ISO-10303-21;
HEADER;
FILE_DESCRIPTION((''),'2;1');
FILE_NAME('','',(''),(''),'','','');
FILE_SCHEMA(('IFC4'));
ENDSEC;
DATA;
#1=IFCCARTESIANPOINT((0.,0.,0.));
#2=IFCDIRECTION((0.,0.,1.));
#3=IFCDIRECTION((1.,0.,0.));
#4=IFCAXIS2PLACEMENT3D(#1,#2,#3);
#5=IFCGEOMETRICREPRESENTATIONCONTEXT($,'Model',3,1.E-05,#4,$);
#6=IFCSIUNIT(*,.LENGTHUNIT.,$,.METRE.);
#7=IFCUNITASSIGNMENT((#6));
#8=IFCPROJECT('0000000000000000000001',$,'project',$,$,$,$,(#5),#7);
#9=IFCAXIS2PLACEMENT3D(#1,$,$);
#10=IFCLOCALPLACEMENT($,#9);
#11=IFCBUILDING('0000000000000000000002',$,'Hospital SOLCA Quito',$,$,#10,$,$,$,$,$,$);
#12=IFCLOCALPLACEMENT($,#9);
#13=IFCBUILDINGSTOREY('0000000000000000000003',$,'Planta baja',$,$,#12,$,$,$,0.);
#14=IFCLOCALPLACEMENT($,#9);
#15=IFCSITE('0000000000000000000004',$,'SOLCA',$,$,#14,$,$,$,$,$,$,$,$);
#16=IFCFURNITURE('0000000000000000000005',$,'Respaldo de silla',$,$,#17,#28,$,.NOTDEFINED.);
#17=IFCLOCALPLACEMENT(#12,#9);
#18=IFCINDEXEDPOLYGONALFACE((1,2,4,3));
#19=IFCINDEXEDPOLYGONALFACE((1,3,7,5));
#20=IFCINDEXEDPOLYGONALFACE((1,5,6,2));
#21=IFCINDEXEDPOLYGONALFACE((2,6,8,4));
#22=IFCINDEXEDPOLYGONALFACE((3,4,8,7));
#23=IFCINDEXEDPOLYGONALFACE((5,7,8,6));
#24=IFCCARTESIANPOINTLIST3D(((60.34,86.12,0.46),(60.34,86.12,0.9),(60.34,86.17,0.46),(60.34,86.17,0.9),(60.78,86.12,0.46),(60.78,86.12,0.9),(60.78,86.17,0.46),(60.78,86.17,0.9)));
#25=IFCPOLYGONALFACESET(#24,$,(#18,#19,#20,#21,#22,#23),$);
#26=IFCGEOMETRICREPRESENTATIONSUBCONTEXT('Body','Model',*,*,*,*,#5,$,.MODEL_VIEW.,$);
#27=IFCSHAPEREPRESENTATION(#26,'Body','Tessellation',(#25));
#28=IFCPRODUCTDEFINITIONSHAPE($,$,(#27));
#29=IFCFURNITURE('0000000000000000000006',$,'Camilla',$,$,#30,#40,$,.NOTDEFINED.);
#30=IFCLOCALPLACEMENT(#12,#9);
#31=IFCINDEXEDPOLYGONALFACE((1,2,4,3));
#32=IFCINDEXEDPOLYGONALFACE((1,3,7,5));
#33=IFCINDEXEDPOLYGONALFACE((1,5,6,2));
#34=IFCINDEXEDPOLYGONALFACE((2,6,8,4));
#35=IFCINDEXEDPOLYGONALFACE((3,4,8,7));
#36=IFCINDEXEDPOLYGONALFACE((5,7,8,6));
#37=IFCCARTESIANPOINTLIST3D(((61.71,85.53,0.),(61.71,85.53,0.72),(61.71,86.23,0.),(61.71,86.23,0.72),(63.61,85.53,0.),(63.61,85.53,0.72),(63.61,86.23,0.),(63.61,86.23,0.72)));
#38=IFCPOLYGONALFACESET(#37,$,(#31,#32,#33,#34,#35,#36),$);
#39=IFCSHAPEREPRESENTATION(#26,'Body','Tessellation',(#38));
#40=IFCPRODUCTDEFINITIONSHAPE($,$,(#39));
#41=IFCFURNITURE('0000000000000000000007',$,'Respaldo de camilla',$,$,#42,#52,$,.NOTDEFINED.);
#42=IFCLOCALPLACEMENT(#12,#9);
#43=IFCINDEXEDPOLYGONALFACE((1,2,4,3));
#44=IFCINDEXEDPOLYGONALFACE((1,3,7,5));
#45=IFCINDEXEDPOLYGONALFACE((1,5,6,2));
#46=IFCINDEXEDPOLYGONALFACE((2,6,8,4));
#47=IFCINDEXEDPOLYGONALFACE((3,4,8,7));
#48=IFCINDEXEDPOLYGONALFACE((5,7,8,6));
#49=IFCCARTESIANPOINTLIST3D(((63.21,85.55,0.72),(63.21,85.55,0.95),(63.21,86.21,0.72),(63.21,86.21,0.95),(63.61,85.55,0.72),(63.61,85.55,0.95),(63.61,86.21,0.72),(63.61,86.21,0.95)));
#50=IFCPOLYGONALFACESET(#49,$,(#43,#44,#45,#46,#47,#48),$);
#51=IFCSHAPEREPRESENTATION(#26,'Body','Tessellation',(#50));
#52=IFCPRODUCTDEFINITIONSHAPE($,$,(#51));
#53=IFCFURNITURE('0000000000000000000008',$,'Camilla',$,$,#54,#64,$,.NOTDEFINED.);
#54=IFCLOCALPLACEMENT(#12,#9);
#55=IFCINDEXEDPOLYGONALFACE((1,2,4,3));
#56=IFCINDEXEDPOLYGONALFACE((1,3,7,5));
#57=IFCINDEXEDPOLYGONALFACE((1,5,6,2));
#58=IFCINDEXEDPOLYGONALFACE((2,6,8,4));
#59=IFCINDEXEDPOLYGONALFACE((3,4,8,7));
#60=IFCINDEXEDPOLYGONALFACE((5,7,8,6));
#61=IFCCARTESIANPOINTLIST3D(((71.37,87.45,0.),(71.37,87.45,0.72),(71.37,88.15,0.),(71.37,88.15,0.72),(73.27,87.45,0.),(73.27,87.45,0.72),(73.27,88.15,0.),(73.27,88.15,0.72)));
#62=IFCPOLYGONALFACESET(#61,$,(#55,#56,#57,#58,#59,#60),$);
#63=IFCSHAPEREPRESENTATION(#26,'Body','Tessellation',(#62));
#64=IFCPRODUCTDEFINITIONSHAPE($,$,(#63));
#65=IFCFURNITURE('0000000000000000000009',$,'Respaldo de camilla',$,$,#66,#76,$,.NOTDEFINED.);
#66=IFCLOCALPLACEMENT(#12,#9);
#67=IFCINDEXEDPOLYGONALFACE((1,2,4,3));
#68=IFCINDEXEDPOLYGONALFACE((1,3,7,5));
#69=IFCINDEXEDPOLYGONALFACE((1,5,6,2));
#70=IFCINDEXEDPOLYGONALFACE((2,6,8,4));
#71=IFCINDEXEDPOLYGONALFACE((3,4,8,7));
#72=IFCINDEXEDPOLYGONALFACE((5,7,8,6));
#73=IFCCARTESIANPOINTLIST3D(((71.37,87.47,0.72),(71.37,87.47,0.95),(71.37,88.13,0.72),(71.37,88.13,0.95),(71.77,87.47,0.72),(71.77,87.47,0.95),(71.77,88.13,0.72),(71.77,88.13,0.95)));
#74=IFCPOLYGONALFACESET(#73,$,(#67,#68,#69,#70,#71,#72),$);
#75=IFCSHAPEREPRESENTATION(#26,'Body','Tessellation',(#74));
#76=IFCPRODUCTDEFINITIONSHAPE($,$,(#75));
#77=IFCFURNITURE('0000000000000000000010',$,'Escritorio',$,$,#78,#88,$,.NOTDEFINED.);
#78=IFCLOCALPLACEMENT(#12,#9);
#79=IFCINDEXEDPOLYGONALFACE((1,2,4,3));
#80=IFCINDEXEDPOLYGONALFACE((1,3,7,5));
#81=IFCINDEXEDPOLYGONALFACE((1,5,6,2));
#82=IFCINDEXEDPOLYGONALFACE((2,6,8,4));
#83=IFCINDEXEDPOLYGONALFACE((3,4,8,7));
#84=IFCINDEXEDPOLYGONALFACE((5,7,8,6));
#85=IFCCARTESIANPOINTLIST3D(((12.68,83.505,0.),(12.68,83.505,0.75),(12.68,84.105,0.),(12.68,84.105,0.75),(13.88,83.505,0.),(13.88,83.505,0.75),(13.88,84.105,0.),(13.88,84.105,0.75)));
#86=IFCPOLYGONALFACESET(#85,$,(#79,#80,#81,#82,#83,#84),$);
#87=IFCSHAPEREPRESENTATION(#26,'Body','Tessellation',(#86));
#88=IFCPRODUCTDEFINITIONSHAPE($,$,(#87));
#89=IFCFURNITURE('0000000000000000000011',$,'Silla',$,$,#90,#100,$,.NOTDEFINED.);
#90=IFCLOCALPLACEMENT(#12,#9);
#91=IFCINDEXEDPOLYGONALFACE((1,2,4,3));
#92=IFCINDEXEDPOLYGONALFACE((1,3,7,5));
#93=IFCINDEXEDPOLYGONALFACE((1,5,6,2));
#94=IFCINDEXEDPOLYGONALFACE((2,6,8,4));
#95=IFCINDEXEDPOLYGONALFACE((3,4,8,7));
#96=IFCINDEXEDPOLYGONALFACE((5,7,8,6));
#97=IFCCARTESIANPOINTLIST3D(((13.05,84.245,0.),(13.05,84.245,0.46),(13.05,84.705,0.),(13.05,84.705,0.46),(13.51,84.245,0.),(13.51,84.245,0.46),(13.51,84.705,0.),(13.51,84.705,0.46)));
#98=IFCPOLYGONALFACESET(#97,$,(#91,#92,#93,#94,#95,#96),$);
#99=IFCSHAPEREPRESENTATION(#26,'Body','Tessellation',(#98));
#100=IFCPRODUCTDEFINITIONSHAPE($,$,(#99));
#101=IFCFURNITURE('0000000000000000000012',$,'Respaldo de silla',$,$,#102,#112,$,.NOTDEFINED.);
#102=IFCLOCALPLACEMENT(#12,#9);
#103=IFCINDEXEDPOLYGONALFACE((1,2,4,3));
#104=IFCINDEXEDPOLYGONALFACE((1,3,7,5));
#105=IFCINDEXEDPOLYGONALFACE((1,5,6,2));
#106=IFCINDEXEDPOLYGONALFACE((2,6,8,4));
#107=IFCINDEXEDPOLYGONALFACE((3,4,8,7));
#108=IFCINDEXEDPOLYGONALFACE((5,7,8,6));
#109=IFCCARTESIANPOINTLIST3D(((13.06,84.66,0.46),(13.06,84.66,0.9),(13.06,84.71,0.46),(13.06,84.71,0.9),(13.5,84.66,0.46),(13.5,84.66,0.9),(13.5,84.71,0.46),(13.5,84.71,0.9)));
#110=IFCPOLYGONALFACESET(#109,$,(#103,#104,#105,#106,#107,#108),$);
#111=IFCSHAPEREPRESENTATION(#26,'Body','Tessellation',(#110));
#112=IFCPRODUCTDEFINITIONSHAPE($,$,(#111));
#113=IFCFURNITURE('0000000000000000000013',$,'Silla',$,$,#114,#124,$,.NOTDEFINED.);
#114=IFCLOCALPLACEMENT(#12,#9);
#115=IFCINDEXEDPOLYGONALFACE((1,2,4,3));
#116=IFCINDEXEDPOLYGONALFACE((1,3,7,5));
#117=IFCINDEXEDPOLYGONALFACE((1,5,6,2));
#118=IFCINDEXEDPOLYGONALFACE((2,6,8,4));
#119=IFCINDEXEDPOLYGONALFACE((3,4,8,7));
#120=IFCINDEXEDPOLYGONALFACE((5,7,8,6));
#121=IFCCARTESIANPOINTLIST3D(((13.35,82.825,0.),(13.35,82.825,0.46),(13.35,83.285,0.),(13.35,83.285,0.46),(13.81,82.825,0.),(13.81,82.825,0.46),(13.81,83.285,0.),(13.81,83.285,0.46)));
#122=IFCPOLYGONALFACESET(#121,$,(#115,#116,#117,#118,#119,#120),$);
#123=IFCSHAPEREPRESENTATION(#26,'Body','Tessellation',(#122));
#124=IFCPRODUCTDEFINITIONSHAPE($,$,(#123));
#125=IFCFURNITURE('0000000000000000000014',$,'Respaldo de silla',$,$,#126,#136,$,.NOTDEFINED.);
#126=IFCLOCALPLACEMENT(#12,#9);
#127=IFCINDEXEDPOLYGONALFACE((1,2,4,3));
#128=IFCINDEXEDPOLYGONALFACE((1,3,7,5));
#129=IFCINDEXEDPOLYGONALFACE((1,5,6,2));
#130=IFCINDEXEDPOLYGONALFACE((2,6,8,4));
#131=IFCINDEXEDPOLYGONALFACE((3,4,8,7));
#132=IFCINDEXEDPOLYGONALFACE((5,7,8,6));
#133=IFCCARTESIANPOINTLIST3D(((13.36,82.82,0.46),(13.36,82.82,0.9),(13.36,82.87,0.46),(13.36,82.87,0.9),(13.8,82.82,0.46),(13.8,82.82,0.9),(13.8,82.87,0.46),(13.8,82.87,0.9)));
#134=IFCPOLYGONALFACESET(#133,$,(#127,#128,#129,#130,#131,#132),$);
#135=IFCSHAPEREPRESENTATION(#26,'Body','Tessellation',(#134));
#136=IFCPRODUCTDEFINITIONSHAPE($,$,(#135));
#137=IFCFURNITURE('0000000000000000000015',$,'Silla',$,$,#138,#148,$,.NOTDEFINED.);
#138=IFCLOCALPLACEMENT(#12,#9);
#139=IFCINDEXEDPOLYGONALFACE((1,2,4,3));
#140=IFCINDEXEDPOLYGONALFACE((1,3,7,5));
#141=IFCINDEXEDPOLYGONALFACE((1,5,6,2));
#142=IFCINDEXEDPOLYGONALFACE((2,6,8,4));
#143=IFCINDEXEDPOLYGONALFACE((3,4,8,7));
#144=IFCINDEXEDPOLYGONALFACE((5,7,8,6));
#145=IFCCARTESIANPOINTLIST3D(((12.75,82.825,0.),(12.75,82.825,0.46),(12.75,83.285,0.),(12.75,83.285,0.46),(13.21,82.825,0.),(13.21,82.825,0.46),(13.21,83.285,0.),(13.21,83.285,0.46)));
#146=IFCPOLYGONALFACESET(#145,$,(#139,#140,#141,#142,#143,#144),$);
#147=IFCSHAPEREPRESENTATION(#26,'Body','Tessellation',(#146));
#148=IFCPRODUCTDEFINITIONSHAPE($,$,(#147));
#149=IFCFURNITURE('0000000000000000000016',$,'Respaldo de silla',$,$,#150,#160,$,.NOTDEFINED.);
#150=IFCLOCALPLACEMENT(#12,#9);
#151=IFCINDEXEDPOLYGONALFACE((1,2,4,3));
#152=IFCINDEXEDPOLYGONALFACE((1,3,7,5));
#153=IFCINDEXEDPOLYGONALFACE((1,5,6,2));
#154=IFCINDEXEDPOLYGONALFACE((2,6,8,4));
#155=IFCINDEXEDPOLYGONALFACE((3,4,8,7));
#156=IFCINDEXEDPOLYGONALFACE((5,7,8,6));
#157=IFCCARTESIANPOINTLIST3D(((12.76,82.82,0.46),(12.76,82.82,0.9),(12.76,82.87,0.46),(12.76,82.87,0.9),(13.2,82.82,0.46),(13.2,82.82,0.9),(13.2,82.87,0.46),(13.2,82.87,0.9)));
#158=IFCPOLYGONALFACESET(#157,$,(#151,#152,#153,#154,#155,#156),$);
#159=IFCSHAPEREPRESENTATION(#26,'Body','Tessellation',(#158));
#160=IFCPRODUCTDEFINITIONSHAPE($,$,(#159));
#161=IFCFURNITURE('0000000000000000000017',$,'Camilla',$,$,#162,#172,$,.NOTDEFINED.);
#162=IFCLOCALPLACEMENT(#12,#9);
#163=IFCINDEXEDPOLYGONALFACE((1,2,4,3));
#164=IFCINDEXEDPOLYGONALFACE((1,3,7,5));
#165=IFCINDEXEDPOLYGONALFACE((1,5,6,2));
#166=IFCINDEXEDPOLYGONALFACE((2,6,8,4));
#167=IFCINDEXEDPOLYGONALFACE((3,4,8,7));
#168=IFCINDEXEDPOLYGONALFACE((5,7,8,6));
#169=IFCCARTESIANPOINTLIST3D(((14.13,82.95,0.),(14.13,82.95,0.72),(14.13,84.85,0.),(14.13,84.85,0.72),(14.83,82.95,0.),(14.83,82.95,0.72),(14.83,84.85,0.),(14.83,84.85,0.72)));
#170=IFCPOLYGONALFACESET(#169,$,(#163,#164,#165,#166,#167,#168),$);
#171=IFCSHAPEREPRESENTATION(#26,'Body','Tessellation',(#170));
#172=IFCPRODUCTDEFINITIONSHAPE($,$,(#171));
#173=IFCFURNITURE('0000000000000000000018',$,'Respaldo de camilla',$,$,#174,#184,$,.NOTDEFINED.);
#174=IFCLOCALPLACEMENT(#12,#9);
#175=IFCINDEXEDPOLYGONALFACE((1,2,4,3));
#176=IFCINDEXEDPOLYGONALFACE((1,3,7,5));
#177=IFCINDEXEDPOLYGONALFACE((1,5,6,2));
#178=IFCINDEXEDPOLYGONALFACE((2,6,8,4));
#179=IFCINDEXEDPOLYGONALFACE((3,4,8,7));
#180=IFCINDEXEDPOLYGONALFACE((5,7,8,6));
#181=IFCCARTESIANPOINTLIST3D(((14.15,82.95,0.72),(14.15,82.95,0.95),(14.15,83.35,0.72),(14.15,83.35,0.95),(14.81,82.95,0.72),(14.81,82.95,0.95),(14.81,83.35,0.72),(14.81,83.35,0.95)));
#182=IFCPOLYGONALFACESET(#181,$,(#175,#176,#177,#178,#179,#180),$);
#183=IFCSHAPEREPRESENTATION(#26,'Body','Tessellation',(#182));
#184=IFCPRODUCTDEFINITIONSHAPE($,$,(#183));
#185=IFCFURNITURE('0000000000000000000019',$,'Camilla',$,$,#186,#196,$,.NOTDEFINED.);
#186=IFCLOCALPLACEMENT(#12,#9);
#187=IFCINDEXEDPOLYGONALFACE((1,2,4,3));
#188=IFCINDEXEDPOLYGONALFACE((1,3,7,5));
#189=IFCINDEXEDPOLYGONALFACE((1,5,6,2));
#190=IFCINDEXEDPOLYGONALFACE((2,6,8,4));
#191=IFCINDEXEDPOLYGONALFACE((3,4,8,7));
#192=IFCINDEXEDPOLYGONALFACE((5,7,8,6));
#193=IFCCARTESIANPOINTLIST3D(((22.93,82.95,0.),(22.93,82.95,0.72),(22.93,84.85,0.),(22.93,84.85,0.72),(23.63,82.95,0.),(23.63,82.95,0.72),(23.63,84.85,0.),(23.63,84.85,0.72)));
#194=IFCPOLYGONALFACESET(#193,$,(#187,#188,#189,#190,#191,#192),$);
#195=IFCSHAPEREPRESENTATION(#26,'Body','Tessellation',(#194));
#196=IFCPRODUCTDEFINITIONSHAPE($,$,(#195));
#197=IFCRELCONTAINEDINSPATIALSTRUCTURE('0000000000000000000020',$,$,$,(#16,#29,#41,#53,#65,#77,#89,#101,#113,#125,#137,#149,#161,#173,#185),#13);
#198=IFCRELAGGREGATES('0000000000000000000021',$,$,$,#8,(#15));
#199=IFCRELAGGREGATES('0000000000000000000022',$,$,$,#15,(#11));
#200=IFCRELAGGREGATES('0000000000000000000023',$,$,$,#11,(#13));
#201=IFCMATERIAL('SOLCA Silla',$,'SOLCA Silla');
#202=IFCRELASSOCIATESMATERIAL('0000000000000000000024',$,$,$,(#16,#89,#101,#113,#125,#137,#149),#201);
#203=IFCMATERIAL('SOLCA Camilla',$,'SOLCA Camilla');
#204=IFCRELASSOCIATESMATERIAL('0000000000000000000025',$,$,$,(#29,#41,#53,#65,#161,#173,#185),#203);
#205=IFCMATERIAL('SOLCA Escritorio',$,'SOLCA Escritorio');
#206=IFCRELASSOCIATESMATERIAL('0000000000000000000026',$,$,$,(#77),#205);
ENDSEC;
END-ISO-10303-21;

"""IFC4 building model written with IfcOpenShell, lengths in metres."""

from ifc_helpers import new_model, si_unit, frame, origin, origin_with_axes, place, context, subcontext, project, spatial, polyline, outline, extrude, material, element, save


model = new_model("IFC4")

# Units and contexts
model_context = context("Model", 3, precision=1e-05, world=origin_with_axes())
body_context = subcontext(model_context, "Body", "Model", "MODEL_VIEW")
ifc_project = project(units=[si_unit("LENGTHUNIT", "METRE")], contexts=[model_context])

# Site, building, storey
site_placement = place(None, origin())
site = spatial("IfcSite", under=ifc_project, at=site_placement, Name="SOLCA")
building_placement = place(None, origin())
building = spatial("IfcBuilding", under=site, at=building_placement, Name="Hospital SOLCA Quito")
storey_placement = place(None, origin())
storey = spatial("IfcBuildingStorey", under=building, at=storey_placement, Name="Planta baja", Elevation=0.0)

# Furniture
ifc_material_1 = material(Name="SOLCA Escritorio", Category="SOLCA Escritorio")
ifc_material_2 = material(Name="SOLCA Silla", Category="SOLCA Silla")
ifc_material_3 = material(Name="SOLCA Camilla", Category="SOLCA Camilla")
furniture_1_placement = place(storey_placement, origin_with_axes())
element("IfcFurniture", 1, at=furniture_1_placement, inside=storey, material=ifc_material_2, Name="Respaldo de silla", PredefinedType="NOTDEFINED", context=body_context, shape_type="SweptSolid", body=[
    extrude(outline(polyline([(60.78, 86.17), (60.34, 86.17), (60.34, 86.12), (60.78, 86.12), (60.78, 86.17)])), frame((0.0, 0.0, 0.46), z_axis=(0.0, 0.0, 1.0), x_axis=(1.0, 0.0, 0.0)), (0.0, 0.0, 1.0), 0.44),
])
furniture_2_placement = place(storey_placement, origin_with_axes())
element("IfcFurniture", 2, at=furniture_2_placement, inside=storey, material=ifc_material_3, Name="Camilla", PredefinedType="NOTDEFINED", context=body_context, shape_type="SweptSolid", body=[
    extrude(outline(polyline([(61.71, 85.53), (63.61, 85.53), (63.61, 86.23), (61.71, 86.23), (61.71, 85.53)])), origin_with_axes(), (0.0, 0.0, 1.0), 0.72),
])
furniture_3_placement = place(storey_placement, origin_with_axes())
element("IfcFurniture", 3, at=furniture_3_placement, inside=storey, material=ifc_material_3, Name="Respaldo de camilla", PredefinedType="NOTDEFINED", context=body_context, shape_type="SweptSolid", body=[
    extrude(outline(polyline([(63.21, 85.55), (63.61, 85.55), (63.61, 86.21), (63.21, 86.21), (63.21, 85.55)])), frame((0.0, 0.0, 0.72), z_axis=(0.0, 0.0, 1.0), x_axis=(1.0, 0.0, 0.0)), (0.0, 0.0, 1.0), 0.23),
])
furniture_4_placement = place(storey_placement, origin_with_axes())
element("IfcFurniture", 4, at=furniture_4_placement, inside=storey, material=ifc_material_3, Name="Camilla", PredefinedType="NOTDEFINED", context=body_context, shape_type="SweptSolid", body=[
    extrude(outline(polyline([(73.27, 88.15), (71.37, 88.15), (71.37, 87.45), (73.27, 87.45), (73.27, 88.15)])), origin_with_axes(), (0.0, 0.0, 1.0), 0.72),
])
furniture_5_placement = place(storey_placement, origin_with_axes())
element("IfcFurniture", 5, at=furniture_5_placement, inside=storey, material=ifc_material_3, Name="Respaldo de camilla", PredefinedType="NOTDEFINED", context=body_context, shape_type="SweptSolid", body=[
    extrude(outline(polyline([(71.77, 88.13), (71.37, 88.13), (71.37, 87.47), (71.77, 87.47), (71.77, 88.13)])), frame((0.0, 0.0, 0.72), z_axis=(0.0, 0.0, 1.0), x_axis=(1.0, 0.0, 0.0)), (0.0, 0.0, 1.0), 0.23),
])
furniture_6_placement = place(storey_placement, origin_with_axes())
element("IfcFurniture", 6, at=furniture_6_placement, inside=storey, material=ifc_material_1, Name="Escritorio", PredefinedType="NOTDEFINED", context=body_context, shape_type="SweptSolid", body=[
    extrude(outline(polyline([(13.88, 84.105), (12.68, 84.105), (12.68, 83.505), (13.88, 83.505), (13.88, 84.105)])), origin_with_axes(), (0.0, 0.0, 1.0), 0.75),
])
furniture_7_placement = place(storey_placement, origin_with_axes())
element("IfcFurniture", 7, at=furniture_7_placement, inside=storey, material=ifc_material_2, Name="Silla", PredefinedType="NOTDEFINED", context=body_context, shape_type="SweptSolid", body=[
    extrude(outline(polyline([(13.51, 84.705), (13.05, 84.705), (13.05, 84.245), (13.51, 84.245), (13.51, 84.705)])), origin_with_axes(), (0.0, 0.0, 1.0), 0.46),
])
furniture_8_placement = place(storey_placement, origin_with_axes())
element("IfcFurniture", 8, at=furniture_8_placement, inside=storey, material=ifc_material_2, Name="Respaldo de silla", PredefinedType="NOTDEFINED", context=body_context, shape_type="SweptSolid", body=[
    extrude(outline(polyline([(13.5, 84.71), (13.06, 84.71), (13.06, 84.66), (13.5, 84.66), (13.5, 84.71)])), frame((0.0, 0.0, 0.46), z_axis=(0.0, 0.0, 1.0), x_axis=(1.0, 0.0, 0.0)), (0.0, 0.0, 1.0), 0.44),
])
furniture_9_placement = place(storey_placement, origin_with_axes())
element("IfcFurniture", 9, at=furniture_9_placement, inside=storey, material=ifc_material_2, Name="Silla", PredefinedType="NOTDEFINED", context=body_context, shape_type="SweptSolid", body=[
    extrude(outline(polyline([(13.81, 83.285), (13.35, 83.285), (13.35, 82.825), (13.81, 82.825), (13.81, 83.285)])), origin_with_axes(), (0.0, 0.0, 1.0), 0.46),
])
furniture_10_placement = place(storey_placement, origin_with_axes())
element("IfcFurniture", 10, at=furniture_10_placement, inside=storey, material=ifc_material_2, Name="Respaldo de silla", PredefinedType="NOTDEFINED", context=body_context, shape_type="SweptSolid", body=[
    extrude(outline(polyline([(13.8, 82.87), (13.36, 82.87), (13.36, 82.82), (13.8, 82.82), (13.8, 82.87)])), frame((0.0, 0.0, 0.46), z_axis=(0.0, 0.0, 1.0), x_axis=(1.0, 0.0, 0.0)), (0.0, 0.0, 1.0), 0.44),
])
furniture_11_placement = place(storey_placement, origin_with_axes())
element("IfcFurniture", 11, at=furniture_11_placement, inside=storey, material=ifc_material_2, Name="Silla", PredefinedType="NOTDEFINED", context=body_context, shape_type="SweptSolid", body=[
    extrude(outline(polyline([(13.21, 83.285), (12.75, 83.285), (12.75, 82.825), (13.21, 82.825), (13.21, 83.285)])), origin_with_axes(), (0.0, 0.0, 1.0), 0.46),
])
furniture_12_placement = place(storey_placement, origin_with_axes())
element("IfcFurniture", 12, at=furniture_12_placement, inside=storey, material=ifc_material_2, Name="Respaldo de silla", PredefinedType="NOTDEFINED", context=body_context, shape_type="SweptSolid", body=[
    extrude(outline(polyline([(13.2, 82.87), (12.76, 82.87), (12.76, 82.82), (13.2, 82.82), (13.2, 82.87)])), frame((0.0, 0.0, 0.46), z_axis=(0.0, 0.0, 1.0), x_axis=(1.0, 0.0, 0.0)), (0.0, 0.0, 1.0), 0.44),
])
furniture_13_placement = place(storey_placement, origin_with_axes())
element("IfcFurniture", 13, at=furniture_13_placement, inside=storey, material=ifc_material_3, Name="Camilla", PredefinedType="NOTDEFINED", context=body_context, shape_type="SweptSolid", body=[
    extrude(outline(polyline([(14.13, 84.85), (14.13, 82.95), (14.83, 82.95), (14.83, 84.85), (14.13, 84.85)])), origin_with_axes(), (0.0, 0.0, 1.0), 0.72),
])
furniture_14_placement = place(storey_placement, origin_with_axes())
element("IfcFurniture", 14, at=furniture_14_placement, inside=storey, material=ifc_material_3, Name="Respaldo de camilla", PredefinedType="NOTDEFINED", context=body_context, shape_type="SweptSolid", body=[
    extrude(outline(polyline([(14.15, 83.35), (14.15, 82.95), (14.81, 82.95), (14.81, 83.35), (14.15, 83.35)])), frame((0.0, 0.0, 0.72), z_axis=(0.0, 0.0, 1.0), x_axis=(1.0, 0.0, 0.0)), (0.0, 0.0, 1.0), 0.23),
])
furniture_15_placement = place(storey_placement, origin_with_axes())
element("IfcFurniture", 15, at=furniture_15_placement, inside=storey, material=ifc_material_3, Name="Camilla", PredefinedType="NOTDEFINED", context=body_context, shape_type="SweptSolid", body=[
    extrude(outline(polyline([(23.63, 82.95), (23.63, 84.85), (22.93, 84.85), (22.93, 82.95), (23.63, 82.95)])), origin_with_axes(), (0.0, 0.0, 1.0), 0.72),
])

save(model, "model.ifc")
